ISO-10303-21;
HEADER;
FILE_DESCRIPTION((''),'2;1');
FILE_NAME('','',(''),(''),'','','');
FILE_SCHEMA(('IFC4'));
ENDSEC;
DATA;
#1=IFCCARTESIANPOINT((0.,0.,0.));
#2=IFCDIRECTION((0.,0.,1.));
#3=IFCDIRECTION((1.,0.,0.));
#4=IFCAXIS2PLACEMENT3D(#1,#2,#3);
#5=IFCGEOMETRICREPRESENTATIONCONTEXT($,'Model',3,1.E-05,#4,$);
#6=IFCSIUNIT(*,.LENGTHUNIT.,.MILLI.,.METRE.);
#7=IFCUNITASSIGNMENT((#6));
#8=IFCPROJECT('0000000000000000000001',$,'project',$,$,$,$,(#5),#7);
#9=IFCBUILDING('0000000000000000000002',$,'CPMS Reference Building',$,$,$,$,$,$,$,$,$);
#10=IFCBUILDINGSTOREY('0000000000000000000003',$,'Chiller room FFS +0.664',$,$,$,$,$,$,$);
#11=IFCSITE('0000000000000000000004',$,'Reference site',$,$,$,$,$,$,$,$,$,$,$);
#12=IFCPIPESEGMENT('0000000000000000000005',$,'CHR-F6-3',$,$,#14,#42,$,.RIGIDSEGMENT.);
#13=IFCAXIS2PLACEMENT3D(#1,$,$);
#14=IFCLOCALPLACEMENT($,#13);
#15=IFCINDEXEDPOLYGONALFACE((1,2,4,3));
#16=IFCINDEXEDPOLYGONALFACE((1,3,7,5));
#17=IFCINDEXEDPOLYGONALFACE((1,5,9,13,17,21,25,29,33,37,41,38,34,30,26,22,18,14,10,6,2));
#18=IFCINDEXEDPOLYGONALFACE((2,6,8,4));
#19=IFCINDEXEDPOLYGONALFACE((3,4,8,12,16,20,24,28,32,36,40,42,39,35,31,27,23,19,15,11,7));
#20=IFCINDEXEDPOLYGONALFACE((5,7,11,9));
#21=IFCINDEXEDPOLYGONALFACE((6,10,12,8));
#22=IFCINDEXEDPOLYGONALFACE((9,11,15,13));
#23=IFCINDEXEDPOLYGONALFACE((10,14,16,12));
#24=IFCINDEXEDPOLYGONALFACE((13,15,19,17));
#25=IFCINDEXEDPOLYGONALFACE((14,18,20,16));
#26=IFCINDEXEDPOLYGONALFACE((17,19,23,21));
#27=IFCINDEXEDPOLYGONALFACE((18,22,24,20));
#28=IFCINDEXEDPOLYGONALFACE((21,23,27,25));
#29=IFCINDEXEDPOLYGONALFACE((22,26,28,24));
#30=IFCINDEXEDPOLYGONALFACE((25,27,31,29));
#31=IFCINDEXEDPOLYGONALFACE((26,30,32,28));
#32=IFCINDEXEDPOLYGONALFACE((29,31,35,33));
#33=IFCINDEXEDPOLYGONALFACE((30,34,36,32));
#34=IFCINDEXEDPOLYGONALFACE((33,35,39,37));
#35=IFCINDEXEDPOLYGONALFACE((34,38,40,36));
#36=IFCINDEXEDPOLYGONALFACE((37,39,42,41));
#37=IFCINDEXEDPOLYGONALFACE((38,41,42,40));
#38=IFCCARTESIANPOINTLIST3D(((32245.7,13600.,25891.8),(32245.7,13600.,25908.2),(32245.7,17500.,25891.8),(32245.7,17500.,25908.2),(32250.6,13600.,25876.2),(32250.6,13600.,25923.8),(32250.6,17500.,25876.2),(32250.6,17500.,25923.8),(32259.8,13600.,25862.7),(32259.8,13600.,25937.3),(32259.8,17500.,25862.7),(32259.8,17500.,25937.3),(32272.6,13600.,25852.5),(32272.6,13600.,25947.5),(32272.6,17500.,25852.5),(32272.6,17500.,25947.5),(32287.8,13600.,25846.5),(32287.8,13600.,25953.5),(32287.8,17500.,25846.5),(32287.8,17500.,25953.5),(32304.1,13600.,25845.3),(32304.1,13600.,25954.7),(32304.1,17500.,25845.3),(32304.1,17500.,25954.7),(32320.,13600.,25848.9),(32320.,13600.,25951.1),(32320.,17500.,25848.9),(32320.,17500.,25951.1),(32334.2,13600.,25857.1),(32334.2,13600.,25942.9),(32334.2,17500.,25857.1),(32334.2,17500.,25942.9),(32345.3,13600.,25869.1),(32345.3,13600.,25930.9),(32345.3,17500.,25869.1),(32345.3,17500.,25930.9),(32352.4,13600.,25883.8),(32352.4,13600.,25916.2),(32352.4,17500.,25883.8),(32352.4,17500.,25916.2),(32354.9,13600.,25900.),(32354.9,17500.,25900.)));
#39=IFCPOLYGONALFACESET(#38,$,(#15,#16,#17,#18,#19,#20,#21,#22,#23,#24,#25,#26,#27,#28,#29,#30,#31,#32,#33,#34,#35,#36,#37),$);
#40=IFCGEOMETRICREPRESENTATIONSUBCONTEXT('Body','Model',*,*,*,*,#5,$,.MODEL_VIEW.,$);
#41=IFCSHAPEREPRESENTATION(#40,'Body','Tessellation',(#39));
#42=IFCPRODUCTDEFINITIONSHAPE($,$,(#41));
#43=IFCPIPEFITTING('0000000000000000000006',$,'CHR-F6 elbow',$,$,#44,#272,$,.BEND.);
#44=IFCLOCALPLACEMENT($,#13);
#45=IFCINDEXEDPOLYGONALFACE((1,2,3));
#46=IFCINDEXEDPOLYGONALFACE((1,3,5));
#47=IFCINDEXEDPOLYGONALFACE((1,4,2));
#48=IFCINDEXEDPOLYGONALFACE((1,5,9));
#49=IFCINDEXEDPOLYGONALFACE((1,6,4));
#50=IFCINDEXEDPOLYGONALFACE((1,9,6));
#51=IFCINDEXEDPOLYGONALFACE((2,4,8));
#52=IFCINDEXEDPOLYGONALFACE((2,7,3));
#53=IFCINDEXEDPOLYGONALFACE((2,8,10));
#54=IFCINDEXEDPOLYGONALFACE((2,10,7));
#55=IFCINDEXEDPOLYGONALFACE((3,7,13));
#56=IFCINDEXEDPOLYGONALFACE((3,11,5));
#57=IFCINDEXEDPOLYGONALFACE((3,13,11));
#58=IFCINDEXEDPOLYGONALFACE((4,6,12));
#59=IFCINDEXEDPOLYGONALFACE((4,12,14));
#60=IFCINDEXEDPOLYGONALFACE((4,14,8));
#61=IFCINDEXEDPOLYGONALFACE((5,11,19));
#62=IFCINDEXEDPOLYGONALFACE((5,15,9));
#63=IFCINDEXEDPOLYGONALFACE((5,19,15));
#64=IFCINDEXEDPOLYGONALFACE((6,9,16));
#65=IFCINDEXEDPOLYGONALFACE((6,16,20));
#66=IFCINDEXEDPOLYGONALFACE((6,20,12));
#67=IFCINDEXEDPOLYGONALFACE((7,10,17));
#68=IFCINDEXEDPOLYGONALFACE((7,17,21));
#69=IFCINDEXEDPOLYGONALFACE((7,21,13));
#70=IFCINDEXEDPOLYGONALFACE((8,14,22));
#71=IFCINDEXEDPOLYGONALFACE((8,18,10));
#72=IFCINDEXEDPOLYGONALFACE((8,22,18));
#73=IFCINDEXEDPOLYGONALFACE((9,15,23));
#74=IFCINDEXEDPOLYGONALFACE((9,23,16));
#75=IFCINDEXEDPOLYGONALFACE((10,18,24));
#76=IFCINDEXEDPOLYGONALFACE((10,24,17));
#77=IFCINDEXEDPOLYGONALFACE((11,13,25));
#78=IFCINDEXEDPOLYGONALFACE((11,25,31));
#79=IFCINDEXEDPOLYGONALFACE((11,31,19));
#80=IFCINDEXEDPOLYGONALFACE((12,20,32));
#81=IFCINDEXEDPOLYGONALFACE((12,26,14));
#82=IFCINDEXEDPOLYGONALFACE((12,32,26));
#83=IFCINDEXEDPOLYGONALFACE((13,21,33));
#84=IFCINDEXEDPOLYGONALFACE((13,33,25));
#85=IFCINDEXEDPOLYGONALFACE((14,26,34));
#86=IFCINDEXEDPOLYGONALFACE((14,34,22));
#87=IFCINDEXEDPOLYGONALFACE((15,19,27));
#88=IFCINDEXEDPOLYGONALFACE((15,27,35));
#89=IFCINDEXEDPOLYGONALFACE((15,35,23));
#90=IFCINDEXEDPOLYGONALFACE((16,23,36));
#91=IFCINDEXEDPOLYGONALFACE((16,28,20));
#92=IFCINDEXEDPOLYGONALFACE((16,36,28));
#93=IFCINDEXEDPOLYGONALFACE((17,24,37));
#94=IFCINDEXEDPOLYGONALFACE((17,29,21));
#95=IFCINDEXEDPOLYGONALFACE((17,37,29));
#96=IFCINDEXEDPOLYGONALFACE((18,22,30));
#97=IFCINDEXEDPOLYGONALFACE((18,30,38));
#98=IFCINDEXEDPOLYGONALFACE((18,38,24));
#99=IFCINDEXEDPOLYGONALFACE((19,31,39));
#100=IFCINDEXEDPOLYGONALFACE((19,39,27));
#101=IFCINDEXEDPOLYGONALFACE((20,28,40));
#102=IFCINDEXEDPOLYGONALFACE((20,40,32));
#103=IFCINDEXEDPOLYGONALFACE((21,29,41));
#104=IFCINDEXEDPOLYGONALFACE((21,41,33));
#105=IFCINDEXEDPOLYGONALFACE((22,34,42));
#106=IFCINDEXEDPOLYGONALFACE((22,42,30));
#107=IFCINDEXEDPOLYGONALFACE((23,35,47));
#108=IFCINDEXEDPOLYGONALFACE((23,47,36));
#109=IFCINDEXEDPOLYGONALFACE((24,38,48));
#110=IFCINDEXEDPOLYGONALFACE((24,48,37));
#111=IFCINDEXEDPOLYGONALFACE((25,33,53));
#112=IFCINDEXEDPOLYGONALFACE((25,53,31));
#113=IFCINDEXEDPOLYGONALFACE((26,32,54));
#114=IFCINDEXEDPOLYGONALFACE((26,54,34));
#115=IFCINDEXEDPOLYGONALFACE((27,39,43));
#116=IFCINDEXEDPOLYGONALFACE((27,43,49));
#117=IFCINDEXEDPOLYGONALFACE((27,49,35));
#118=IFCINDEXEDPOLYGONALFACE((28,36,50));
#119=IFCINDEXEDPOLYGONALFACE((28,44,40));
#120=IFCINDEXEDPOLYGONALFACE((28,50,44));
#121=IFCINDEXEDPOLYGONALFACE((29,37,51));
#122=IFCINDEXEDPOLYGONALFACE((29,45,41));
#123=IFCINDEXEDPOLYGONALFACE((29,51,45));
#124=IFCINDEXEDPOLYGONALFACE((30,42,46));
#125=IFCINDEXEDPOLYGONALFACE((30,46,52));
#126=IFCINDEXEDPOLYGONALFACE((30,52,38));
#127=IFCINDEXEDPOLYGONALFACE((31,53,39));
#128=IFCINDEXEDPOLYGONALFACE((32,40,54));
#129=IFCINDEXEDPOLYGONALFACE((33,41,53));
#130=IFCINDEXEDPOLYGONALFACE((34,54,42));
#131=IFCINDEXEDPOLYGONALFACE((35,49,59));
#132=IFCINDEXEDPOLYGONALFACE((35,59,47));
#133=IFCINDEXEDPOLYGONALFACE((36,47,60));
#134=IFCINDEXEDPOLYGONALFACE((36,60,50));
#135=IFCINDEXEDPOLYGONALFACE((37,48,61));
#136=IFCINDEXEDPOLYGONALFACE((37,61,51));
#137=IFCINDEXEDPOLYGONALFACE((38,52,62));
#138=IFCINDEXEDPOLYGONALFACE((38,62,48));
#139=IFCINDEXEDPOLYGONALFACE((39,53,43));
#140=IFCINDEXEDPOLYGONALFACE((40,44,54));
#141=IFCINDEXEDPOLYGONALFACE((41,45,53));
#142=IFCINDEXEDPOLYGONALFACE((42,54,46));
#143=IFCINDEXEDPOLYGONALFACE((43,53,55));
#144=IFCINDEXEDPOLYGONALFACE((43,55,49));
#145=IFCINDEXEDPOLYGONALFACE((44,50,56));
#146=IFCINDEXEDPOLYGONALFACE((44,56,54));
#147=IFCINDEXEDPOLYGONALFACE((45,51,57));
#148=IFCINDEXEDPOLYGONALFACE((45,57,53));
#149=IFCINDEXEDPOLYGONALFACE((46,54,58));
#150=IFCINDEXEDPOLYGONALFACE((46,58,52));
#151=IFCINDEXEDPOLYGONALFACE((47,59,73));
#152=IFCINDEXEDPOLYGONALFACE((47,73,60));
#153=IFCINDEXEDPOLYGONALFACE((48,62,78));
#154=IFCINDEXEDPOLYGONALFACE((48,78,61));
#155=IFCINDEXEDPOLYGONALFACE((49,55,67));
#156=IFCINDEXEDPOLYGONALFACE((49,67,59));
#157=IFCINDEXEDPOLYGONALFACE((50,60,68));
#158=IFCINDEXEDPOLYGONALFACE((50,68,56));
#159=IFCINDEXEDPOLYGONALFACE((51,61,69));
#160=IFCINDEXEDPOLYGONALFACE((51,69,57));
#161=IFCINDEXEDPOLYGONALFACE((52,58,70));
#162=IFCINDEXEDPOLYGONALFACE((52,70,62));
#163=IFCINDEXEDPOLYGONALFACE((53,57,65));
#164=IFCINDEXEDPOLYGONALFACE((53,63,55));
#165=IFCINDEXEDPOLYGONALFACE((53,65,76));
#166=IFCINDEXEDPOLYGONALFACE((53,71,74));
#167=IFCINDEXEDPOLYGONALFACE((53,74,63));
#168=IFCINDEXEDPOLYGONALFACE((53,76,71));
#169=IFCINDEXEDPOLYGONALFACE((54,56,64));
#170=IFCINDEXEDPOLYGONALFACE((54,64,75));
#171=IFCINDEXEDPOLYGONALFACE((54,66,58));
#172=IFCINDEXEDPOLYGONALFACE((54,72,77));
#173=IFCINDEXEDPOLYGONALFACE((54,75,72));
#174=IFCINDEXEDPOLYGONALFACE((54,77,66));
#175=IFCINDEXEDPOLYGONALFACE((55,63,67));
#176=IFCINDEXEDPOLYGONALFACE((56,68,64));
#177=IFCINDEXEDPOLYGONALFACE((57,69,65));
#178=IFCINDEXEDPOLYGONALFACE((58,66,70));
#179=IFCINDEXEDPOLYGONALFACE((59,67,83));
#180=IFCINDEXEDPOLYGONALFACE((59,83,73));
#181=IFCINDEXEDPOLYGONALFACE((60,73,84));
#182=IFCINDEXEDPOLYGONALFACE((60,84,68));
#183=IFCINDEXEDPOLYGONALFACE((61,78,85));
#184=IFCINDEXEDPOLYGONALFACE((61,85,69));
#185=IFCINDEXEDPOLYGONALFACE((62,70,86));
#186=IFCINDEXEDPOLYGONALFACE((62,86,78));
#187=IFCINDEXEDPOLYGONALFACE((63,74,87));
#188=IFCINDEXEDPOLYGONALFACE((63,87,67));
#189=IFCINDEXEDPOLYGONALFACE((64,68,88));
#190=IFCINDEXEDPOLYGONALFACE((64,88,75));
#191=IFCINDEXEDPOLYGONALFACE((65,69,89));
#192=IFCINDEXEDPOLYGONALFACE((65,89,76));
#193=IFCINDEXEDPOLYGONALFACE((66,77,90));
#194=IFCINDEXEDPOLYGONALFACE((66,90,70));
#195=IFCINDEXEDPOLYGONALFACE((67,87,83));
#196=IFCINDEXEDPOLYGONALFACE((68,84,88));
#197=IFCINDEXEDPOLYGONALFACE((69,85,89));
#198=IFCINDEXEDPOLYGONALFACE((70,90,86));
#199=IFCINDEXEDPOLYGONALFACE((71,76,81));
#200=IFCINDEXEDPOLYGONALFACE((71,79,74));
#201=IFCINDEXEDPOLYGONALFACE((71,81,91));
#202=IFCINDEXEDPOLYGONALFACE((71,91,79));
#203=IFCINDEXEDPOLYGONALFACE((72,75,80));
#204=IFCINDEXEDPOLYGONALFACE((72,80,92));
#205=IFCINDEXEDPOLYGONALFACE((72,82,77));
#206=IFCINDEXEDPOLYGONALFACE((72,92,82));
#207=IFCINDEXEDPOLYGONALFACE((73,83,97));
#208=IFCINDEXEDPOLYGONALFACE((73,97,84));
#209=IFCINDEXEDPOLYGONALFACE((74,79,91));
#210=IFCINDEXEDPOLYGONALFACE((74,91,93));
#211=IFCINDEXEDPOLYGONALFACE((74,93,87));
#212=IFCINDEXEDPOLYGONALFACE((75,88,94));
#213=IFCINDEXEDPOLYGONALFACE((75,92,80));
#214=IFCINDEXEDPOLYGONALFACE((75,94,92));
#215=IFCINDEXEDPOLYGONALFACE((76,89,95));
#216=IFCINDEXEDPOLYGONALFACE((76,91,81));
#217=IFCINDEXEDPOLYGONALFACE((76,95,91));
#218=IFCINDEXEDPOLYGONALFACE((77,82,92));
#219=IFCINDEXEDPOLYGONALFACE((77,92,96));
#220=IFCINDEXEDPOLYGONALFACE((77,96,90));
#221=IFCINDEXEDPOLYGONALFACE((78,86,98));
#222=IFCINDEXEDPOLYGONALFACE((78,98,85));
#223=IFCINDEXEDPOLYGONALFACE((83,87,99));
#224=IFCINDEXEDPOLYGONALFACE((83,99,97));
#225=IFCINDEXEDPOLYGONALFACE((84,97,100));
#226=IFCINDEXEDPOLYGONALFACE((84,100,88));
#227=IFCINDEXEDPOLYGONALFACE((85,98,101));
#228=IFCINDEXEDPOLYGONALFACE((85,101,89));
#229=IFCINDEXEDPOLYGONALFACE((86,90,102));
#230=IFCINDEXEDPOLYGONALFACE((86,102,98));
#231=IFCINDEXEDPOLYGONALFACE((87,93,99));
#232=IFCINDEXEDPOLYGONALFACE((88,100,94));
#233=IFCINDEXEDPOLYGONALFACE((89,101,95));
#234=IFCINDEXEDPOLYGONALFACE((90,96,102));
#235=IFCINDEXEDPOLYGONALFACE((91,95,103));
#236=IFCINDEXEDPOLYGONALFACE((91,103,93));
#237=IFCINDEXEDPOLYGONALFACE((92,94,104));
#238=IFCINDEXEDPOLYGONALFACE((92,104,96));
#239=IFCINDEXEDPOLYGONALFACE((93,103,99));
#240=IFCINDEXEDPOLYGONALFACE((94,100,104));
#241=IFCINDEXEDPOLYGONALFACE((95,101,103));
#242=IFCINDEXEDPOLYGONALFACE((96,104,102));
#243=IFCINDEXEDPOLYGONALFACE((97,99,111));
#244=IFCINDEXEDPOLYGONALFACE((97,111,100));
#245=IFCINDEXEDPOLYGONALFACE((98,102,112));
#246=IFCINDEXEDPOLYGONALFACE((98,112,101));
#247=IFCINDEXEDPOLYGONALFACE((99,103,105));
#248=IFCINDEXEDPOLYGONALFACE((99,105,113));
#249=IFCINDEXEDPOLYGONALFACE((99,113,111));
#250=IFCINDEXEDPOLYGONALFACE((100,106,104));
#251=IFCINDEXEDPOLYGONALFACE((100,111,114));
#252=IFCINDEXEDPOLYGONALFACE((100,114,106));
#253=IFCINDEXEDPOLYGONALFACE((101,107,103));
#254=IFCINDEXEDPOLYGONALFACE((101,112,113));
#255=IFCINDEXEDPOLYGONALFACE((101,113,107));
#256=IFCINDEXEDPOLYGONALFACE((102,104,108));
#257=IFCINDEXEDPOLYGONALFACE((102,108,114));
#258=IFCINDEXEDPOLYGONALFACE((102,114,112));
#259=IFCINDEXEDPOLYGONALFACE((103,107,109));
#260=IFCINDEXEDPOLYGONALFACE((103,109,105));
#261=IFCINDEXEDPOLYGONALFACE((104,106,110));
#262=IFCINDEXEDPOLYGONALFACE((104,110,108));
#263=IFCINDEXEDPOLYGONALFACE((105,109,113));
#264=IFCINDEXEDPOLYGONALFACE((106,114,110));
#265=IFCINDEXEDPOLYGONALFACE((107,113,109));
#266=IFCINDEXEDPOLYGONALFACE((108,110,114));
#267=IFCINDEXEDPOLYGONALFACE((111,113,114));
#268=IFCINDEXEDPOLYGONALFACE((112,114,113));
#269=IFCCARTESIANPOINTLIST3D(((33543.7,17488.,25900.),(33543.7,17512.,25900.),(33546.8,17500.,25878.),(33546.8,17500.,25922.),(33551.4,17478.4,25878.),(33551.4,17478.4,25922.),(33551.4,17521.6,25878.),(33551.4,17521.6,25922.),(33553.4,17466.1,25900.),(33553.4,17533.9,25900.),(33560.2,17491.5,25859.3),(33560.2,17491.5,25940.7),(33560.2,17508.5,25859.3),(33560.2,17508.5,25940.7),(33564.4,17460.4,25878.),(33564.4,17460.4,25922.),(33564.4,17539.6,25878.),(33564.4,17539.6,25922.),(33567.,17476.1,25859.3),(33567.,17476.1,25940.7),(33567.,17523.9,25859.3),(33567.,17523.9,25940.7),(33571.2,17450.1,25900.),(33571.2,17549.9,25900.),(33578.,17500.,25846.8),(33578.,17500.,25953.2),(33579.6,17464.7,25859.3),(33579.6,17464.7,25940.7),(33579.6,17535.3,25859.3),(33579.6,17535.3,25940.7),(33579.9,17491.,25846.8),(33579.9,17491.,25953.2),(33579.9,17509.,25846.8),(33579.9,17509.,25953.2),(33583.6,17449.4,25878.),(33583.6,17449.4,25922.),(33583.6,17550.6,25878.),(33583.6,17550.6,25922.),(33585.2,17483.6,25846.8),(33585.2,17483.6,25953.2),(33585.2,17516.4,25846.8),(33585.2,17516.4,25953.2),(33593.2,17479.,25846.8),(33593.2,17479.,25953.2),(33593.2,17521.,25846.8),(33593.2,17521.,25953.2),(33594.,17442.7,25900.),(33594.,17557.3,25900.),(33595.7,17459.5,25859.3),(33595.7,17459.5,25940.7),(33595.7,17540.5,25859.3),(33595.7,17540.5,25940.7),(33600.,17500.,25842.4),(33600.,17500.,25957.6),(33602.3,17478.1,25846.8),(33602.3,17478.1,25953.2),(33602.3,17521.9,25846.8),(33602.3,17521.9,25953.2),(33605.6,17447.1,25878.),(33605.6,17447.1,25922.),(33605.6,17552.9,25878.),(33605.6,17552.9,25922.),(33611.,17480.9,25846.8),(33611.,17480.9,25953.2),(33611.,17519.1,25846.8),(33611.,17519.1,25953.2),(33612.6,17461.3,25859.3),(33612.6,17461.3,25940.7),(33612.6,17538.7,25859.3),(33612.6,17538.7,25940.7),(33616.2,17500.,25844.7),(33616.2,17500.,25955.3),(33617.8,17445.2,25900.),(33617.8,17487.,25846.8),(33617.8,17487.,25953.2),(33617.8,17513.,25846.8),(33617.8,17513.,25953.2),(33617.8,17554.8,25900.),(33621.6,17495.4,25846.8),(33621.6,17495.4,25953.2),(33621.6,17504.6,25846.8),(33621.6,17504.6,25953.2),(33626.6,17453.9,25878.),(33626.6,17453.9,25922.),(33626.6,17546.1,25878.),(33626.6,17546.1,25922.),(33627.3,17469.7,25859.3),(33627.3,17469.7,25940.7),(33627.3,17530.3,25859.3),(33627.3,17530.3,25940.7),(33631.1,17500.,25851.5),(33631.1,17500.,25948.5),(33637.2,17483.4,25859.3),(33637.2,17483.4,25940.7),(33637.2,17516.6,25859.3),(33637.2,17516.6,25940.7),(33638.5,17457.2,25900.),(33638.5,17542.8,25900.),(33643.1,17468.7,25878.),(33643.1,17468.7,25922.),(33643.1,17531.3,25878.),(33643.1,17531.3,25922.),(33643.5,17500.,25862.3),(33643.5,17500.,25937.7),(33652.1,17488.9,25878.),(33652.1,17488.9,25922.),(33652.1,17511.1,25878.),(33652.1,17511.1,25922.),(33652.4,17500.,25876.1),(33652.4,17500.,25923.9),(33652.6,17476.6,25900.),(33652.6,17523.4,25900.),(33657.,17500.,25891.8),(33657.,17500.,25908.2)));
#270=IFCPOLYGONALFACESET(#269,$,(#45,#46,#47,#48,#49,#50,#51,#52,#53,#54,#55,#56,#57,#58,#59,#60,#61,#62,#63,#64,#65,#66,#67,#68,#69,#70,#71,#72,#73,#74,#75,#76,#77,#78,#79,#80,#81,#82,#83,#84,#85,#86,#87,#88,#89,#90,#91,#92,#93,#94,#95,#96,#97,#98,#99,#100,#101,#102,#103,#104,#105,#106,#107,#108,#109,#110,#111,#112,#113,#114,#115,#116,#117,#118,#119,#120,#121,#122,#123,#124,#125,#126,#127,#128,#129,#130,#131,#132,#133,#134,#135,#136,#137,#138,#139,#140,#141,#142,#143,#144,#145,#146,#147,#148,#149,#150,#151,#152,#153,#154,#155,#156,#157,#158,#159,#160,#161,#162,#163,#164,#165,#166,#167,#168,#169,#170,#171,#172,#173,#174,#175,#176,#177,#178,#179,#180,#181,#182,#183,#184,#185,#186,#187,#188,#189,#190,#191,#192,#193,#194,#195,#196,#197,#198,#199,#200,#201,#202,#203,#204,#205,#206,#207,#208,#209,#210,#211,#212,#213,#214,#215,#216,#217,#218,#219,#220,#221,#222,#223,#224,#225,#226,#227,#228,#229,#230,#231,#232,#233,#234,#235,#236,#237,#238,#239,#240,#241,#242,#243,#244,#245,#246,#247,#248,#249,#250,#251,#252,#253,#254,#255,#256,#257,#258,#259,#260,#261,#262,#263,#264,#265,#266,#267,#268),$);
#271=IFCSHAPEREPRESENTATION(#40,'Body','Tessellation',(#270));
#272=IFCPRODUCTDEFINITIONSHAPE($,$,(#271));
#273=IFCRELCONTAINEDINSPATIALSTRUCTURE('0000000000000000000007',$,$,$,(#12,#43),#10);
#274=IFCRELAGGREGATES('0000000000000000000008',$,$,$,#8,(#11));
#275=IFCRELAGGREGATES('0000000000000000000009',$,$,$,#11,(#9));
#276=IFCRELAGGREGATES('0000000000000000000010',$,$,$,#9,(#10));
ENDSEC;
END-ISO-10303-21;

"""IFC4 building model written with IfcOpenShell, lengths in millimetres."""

from ifc_helpers import new_model, entity, si_unit, frame, origin_with_axes, origin_2d, place, context, subcontext, project, spatial, circle_curve, outline, extrude, element, save


model = new_model("IFC4")

# Units and contexts
model_context = context("Model", 3, precision=1e-05, world=origin_with_axes())
body_context = subcontext(model_context, "Body", "Model", "MODEL_VIEW")
ifc_project = project(units=[si_unit("LENGTHUNIT", "METRE", prefix="MILLI")], contexts=[model_context])

# Site, building, storey
site = spatial("IfcSite", under=ifc_project, Name="Reference site")
building = spatial("IfcBuilding", under=site, Name="CPMS Reference Building")
storey = spatial("IfcBuildingStorey", under=building, Name="Chiller room FFS +0.664")

# Pipe segment
pipe_segment_1_placement = place(None, origin_with_axes())
element("IfcPipeSegment", 1, at=pipe_segment_1_placement, inside=storey, Name="CHR-F6-3", PredefinedType="RIGIDSEGMENT", context=body_context, shape_type="SweptSolid", body=[
    extrude(outline(circle_curve(origin_2d(), 54.9)), frame((32300.0, 17500.0, 25900.0), z_axis=(0.0, -1.0, 0.0), x_axis=(1.0, 0.0, 0.0)), (0.0, 0.0, 1.0), 3900.0),
])

# Pipe fitting
pipe_fitting_1_placement = place(None, origin_with_axes())
element("IfcPipeFitting", 2, at=pipe_fitting_1_placement, inside=storey, Name="CHR-F6 elbow", PredefinedType="BEND", context=body_context, shape_type="CSG", body=[
    entity("IfcSphere", entity("IfcAxis2Placement3D", entity("IfcCartesianPoint", [33600.0, 17500.0, 25900.0]), entity("IfcDirection", [0.0, 0.0, 1.0]), entity("IfcDirection", [1.0, 0.0, 0.0])), 57.6),
])

save(model, "model.ifc")
